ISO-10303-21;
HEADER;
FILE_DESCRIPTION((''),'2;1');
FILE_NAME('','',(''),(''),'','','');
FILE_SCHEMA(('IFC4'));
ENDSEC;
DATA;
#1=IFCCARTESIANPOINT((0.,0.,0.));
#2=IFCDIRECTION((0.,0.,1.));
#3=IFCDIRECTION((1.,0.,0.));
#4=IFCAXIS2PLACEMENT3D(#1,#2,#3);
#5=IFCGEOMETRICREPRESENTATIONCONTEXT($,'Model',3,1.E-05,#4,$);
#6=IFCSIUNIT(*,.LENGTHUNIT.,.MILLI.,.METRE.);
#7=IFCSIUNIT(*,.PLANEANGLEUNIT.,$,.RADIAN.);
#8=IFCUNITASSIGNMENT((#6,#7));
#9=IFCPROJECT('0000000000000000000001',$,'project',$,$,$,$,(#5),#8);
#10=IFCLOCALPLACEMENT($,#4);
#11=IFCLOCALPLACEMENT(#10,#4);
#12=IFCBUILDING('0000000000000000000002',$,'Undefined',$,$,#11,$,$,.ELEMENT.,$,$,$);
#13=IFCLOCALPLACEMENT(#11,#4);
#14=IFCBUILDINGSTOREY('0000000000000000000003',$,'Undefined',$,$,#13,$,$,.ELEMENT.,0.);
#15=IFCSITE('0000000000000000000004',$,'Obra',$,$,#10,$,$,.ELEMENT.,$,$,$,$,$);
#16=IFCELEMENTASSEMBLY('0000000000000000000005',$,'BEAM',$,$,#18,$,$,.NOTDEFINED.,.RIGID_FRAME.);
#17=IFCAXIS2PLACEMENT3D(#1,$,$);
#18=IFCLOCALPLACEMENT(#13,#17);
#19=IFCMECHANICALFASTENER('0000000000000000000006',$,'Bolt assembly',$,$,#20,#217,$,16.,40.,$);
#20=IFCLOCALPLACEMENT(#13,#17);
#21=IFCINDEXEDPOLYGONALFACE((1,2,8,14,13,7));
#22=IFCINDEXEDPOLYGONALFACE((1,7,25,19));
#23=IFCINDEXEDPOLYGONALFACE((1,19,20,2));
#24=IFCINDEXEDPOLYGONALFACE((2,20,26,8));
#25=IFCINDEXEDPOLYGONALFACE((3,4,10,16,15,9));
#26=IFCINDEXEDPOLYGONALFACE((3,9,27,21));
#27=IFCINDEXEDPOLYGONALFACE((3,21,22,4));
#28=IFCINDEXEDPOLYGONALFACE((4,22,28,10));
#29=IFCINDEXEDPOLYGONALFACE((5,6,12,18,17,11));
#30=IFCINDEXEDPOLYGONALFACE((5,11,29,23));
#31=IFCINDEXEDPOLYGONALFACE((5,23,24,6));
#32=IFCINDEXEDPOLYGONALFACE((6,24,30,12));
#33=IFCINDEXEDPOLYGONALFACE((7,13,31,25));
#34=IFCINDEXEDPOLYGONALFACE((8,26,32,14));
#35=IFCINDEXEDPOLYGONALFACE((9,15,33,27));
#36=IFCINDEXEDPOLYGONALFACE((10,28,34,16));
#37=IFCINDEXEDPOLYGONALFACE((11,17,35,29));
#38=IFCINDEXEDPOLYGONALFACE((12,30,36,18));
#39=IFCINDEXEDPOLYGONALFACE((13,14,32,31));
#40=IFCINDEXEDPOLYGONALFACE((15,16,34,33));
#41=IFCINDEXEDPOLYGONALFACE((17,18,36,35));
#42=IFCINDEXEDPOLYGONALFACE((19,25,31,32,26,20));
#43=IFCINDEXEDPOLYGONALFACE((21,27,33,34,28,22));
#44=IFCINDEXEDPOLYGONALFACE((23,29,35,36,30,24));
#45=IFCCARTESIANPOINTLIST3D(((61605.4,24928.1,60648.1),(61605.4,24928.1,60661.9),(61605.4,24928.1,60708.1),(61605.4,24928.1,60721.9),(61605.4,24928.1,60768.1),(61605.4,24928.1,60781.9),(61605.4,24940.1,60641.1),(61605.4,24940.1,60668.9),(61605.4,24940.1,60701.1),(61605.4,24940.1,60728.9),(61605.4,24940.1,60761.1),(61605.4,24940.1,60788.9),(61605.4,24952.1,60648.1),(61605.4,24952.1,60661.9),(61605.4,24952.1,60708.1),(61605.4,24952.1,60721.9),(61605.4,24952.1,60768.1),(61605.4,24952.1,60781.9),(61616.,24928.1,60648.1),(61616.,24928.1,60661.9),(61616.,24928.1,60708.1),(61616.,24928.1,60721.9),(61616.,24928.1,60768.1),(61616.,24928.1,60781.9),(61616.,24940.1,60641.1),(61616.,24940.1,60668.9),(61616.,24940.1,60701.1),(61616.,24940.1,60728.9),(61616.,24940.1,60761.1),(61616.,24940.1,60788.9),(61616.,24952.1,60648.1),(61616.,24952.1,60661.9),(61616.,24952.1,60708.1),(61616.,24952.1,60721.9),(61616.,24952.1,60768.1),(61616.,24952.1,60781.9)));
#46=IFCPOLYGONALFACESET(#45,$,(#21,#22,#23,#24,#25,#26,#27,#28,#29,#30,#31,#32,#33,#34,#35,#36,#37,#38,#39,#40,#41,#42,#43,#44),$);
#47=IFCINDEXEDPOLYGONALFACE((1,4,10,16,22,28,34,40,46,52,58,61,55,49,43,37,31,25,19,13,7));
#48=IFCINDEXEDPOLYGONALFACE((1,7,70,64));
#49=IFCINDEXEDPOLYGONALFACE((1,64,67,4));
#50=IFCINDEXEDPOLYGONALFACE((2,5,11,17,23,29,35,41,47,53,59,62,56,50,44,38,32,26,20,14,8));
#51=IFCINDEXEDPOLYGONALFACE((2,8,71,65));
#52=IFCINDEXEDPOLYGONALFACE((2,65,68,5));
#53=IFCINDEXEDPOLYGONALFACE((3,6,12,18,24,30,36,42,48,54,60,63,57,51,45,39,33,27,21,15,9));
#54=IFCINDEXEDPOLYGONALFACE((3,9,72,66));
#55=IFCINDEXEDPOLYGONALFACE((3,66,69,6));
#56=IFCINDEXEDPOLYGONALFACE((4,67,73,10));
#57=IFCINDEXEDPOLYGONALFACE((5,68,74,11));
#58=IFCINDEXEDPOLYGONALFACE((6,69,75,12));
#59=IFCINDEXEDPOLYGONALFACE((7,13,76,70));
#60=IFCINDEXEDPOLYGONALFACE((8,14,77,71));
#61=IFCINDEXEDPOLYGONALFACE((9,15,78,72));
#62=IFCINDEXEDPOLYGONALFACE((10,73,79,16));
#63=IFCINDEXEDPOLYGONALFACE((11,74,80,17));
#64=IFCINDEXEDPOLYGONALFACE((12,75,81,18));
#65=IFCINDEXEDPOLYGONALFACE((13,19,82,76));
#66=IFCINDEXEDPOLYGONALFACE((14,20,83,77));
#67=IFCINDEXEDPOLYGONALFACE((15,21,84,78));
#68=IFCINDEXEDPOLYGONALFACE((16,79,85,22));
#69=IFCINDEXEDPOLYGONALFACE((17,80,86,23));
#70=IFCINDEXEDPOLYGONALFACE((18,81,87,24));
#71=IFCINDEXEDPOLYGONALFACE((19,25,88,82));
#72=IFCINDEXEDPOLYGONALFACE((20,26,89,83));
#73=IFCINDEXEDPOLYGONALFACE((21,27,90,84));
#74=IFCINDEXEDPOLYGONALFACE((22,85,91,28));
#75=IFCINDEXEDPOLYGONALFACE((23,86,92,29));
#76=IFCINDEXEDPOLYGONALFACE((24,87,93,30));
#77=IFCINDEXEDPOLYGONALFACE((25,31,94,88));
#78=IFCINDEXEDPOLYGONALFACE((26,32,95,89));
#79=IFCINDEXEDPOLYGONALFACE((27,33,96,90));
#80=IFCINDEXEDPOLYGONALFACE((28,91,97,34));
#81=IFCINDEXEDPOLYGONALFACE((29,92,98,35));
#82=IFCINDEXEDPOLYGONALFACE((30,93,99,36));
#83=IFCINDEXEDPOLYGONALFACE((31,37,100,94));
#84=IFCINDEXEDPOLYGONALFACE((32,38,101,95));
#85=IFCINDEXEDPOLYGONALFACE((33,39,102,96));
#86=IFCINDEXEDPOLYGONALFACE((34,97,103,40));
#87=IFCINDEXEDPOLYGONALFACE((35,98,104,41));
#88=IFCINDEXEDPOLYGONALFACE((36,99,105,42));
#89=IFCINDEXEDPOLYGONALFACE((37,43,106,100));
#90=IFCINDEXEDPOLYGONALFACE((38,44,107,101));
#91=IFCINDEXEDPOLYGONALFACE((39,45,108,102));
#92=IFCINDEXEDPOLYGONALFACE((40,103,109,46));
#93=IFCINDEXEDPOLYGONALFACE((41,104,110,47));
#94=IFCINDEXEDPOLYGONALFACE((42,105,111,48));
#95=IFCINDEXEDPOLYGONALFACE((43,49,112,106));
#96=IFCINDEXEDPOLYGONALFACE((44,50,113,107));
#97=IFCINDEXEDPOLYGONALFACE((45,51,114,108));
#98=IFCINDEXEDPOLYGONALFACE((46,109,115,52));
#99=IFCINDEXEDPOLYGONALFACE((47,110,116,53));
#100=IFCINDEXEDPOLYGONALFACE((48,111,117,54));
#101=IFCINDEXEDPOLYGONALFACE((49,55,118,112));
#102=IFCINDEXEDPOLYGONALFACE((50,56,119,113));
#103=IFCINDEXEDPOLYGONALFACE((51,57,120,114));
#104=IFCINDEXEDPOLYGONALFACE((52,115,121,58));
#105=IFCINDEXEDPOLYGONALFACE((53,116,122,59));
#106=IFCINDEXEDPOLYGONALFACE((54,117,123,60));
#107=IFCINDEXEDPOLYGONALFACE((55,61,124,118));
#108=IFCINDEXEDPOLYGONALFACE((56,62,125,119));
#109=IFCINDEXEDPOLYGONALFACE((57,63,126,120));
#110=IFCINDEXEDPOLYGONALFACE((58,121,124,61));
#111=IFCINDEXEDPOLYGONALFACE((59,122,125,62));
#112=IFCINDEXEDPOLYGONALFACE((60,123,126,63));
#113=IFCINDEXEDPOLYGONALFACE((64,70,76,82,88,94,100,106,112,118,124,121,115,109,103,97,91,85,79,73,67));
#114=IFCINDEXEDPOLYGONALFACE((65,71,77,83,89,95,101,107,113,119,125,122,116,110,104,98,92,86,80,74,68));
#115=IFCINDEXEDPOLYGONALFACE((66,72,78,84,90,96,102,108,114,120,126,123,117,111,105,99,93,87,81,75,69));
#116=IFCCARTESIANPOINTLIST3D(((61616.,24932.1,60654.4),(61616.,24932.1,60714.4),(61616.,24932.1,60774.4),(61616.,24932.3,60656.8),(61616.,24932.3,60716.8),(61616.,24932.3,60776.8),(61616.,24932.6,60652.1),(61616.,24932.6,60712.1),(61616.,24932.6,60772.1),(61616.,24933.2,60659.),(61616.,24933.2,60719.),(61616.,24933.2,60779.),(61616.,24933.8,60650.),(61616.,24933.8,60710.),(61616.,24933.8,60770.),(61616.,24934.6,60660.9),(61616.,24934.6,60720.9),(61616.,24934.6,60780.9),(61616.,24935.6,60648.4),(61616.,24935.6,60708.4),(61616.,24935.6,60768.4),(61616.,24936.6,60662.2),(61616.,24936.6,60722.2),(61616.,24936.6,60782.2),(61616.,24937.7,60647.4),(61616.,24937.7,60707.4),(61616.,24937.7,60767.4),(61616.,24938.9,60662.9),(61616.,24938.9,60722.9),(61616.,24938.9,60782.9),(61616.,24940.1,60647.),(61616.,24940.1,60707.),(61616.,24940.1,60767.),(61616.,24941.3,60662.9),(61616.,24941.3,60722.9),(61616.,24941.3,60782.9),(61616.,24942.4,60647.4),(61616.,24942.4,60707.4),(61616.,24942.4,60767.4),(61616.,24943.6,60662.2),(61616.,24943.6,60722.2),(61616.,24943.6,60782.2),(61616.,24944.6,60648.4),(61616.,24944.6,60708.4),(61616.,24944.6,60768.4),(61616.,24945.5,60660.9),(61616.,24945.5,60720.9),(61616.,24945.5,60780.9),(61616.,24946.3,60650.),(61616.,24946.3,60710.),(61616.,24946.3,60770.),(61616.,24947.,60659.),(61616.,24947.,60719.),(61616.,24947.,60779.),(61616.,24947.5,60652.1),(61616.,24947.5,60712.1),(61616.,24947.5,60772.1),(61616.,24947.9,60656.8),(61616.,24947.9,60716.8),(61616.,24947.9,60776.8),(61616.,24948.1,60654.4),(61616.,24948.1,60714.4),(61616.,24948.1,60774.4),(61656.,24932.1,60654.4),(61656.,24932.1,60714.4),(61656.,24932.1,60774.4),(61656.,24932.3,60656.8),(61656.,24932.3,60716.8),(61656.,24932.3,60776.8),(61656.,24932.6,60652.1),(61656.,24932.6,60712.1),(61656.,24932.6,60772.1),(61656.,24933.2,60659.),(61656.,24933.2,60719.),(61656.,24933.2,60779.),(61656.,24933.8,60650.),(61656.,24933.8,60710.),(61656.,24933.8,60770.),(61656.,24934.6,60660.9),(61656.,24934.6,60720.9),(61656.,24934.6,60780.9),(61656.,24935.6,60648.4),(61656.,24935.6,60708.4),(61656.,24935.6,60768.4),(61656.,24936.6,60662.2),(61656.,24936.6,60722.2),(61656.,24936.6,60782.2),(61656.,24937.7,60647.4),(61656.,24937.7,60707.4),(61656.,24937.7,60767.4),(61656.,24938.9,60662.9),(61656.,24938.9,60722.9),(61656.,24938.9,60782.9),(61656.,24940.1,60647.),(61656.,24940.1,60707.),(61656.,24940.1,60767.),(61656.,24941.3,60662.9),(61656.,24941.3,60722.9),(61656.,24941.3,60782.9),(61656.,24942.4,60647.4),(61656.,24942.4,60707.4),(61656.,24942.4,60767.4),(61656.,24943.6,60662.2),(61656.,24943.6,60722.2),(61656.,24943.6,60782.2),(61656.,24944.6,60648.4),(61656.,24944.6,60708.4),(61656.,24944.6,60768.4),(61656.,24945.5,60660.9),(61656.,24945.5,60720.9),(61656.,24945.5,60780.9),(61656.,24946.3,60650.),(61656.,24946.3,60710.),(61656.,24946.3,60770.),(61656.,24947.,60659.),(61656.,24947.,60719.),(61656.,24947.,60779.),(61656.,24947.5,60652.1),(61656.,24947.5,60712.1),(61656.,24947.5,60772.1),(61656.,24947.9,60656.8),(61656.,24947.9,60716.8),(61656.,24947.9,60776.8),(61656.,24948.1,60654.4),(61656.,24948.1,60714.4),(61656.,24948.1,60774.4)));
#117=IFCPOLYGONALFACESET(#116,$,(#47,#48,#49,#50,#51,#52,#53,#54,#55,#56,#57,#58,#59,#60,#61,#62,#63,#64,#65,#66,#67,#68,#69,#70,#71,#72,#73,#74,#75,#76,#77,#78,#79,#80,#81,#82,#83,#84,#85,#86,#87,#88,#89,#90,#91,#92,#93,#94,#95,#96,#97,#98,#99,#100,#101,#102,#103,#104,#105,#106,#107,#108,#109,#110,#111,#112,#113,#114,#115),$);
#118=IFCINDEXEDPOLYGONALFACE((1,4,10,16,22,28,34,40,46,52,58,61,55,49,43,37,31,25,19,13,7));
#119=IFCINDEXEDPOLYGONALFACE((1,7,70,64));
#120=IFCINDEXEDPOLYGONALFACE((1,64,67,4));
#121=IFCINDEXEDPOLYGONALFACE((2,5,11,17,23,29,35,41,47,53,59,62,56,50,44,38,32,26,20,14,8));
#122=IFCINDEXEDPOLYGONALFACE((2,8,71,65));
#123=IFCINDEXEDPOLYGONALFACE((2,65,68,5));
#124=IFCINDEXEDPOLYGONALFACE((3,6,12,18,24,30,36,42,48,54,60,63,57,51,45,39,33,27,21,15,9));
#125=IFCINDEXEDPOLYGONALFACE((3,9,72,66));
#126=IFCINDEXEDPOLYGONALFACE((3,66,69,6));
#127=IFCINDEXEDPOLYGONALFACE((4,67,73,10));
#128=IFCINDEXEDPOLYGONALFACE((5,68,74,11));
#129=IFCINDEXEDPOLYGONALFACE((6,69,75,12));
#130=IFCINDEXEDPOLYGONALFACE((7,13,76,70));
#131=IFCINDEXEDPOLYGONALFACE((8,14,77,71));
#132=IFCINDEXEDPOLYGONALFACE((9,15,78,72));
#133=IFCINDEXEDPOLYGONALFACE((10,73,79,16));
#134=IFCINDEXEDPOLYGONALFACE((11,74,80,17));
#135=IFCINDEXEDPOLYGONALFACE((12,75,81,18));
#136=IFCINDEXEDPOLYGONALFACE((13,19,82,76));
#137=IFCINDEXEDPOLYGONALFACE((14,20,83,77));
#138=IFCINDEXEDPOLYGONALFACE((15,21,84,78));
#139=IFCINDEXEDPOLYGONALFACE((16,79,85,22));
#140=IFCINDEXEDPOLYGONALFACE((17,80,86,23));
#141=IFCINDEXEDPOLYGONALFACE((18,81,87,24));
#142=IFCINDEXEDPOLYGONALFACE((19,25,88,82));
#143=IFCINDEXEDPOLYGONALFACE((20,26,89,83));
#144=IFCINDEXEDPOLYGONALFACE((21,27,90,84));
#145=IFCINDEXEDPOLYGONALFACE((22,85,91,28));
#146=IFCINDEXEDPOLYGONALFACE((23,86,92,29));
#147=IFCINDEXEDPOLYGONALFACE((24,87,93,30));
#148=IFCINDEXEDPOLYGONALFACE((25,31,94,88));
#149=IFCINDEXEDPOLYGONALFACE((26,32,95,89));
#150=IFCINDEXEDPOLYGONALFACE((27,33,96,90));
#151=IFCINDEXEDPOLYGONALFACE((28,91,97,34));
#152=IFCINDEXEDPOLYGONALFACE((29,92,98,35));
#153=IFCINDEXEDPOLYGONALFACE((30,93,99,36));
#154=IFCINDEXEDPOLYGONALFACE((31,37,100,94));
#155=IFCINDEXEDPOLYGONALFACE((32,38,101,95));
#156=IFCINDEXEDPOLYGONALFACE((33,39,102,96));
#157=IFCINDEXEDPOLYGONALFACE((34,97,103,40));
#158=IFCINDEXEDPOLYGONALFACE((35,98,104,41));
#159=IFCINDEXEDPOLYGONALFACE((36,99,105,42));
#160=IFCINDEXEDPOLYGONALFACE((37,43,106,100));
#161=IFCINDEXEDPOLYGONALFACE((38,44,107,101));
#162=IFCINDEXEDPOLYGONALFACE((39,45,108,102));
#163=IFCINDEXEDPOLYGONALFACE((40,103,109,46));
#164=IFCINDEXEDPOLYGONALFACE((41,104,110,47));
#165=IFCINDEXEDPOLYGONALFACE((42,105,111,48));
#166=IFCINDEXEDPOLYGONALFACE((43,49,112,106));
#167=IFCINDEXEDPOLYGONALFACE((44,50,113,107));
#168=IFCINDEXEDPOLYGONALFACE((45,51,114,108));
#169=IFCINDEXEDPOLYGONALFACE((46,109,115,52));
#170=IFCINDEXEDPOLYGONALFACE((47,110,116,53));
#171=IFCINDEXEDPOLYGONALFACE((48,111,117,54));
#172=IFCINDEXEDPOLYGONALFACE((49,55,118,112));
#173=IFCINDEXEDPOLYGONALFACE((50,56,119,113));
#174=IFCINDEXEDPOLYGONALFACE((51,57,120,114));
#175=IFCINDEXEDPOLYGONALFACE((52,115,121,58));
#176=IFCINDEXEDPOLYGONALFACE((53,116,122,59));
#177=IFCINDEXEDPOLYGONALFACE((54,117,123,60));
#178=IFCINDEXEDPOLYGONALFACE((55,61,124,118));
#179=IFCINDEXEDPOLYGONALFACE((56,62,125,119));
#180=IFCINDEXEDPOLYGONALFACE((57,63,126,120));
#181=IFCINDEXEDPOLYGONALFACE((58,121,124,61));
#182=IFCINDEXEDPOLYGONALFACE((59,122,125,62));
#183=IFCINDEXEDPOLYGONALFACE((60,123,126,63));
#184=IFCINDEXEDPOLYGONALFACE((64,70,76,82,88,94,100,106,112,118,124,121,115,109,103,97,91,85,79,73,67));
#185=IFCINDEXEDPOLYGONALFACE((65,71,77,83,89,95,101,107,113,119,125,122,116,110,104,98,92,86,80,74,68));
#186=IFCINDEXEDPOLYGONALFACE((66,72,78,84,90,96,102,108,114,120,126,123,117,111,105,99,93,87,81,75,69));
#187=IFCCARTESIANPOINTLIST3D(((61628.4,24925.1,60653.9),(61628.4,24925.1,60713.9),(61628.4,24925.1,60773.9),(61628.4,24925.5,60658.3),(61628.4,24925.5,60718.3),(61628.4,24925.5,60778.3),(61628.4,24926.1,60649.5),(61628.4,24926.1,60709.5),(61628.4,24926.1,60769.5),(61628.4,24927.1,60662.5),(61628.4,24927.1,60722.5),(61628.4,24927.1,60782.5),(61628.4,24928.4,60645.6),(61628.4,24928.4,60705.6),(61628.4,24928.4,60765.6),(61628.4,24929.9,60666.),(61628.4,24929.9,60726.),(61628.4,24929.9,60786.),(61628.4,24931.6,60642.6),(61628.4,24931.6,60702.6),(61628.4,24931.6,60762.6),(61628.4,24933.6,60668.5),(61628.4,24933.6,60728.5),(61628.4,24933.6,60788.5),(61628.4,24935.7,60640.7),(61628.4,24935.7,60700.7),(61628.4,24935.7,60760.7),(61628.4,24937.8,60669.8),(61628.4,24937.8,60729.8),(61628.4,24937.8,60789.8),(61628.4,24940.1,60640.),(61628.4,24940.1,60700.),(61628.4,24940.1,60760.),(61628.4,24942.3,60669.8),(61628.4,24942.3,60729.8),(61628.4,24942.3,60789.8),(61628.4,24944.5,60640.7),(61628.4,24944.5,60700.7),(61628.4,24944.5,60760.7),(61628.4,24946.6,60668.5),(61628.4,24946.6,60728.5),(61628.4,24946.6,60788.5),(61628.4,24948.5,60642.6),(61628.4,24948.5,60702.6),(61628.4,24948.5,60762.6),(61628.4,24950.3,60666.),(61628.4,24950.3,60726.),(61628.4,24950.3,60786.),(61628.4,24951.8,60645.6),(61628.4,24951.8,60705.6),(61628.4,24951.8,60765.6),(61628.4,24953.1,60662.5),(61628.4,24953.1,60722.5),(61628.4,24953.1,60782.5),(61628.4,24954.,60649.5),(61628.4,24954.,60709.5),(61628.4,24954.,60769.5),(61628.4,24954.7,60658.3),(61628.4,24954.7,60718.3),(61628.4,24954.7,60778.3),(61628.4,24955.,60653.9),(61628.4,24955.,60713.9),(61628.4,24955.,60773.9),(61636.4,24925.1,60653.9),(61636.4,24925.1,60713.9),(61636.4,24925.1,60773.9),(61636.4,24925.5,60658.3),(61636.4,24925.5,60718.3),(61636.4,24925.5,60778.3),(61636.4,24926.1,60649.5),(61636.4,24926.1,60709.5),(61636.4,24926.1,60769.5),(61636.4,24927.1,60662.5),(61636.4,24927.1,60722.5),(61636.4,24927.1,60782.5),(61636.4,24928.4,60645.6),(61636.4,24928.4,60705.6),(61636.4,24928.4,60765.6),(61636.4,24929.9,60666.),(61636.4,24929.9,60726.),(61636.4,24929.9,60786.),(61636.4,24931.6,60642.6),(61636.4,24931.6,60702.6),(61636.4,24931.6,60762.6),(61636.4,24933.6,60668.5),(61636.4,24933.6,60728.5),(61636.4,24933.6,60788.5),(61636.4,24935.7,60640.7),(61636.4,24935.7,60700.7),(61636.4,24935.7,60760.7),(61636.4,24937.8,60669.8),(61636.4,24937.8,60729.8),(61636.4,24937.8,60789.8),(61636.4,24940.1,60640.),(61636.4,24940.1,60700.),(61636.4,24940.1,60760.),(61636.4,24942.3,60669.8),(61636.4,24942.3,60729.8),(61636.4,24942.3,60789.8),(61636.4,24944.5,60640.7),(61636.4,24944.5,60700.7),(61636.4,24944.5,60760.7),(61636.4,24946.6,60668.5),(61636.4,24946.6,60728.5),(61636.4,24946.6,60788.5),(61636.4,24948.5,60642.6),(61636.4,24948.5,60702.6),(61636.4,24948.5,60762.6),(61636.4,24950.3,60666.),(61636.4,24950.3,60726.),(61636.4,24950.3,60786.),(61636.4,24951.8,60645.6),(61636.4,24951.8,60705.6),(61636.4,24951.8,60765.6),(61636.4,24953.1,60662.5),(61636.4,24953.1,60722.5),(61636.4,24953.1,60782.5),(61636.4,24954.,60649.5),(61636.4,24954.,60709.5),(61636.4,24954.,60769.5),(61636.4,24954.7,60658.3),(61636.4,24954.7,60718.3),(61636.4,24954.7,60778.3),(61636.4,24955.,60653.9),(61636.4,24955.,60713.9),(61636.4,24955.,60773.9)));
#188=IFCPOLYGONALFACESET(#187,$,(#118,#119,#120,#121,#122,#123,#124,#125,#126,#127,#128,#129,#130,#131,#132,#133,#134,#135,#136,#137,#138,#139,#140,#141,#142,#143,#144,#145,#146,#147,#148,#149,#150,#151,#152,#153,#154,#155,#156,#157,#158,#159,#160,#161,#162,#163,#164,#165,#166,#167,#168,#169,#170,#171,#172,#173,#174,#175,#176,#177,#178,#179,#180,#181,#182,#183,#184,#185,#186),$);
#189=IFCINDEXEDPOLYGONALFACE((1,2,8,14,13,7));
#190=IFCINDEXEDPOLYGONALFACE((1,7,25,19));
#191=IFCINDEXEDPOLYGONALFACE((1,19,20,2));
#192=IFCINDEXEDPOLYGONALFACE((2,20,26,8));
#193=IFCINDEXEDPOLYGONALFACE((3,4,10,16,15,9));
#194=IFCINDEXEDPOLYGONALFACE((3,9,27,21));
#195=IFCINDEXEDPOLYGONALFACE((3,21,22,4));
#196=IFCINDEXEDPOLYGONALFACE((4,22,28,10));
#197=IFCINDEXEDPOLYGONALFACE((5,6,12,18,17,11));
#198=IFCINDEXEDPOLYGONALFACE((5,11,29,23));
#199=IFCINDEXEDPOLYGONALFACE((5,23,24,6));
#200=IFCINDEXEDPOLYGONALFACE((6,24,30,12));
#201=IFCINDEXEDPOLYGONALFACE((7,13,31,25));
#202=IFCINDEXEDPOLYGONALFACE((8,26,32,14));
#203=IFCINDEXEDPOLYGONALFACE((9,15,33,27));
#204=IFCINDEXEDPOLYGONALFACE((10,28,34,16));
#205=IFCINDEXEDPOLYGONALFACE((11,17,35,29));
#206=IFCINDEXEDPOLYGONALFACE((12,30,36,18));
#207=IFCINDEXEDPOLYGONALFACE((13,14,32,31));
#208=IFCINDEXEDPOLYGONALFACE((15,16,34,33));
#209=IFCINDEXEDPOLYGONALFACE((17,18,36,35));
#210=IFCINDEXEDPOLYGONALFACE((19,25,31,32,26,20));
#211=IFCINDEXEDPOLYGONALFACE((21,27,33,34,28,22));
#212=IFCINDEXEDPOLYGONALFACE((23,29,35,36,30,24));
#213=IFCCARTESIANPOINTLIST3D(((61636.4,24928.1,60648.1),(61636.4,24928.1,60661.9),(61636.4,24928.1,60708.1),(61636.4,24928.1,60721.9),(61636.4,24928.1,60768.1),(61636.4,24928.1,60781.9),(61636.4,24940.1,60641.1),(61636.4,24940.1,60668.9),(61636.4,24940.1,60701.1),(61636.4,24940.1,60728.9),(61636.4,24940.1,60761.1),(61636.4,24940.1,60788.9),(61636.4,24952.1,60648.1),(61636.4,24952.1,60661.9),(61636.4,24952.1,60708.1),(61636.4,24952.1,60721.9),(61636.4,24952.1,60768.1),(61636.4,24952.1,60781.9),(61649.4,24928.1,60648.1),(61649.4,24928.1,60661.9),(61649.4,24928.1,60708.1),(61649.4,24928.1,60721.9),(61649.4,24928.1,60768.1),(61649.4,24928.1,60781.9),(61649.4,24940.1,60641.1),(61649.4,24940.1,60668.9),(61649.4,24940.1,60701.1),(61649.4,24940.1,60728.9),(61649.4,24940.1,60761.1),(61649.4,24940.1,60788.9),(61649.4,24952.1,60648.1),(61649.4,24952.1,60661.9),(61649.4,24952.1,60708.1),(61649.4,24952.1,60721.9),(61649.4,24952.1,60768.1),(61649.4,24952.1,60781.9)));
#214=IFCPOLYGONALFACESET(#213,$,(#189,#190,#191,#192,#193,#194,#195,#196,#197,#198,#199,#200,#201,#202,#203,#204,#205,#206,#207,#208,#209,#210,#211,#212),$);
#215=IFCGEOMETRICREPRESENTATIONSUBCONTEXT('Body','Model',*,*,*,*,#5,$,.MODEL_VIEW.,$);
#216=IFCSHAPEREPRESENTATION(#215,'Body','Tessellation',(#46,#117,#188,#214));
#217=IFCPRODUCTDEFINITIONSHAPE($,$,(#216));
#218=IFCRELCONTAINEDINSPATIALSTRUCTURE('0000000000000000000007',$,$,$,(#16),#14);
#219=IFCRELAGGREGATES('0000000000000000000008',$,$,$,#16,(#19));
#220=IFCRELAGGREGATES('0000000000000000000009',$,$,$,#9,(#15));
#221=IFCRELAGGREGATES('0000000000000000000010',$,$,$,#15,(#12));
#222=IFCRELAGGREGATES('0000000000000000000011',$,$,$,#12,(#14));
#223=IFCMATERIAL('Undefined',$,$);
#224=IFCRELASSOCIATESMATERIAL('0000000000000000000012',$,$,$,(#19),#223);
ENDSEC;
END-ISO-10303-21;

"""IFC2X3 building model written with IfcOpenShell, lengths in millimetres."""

from ifc_helpers import new_model, si_unit, frame, origin_with_axes, origin_2d_with_axis, place, context, subcontext, project, spatial, polyline, circle, outline, extrude, source, transform, mapped, material, element, aggregate, save


model = new_model("IFC2X3")

# Units and contexts
model_context = context("Model", 3, precision=1e-05, world=origin_with_axes())
body_context = subcontext(model_context, "Body", "Model", "MODEL_VIEW")
ifc_project = project(units=[si_unit("LENGTHUNIT", "METRE", prefix="MILLI"), si_unit("PLANEANGLEUNIT", "RADIAN")], contexts=[model_context])

# Site, building, storey
site_placement = place(None, origin_with_axes())
site = spatial("IfcSite", under=ifc_project, at=site_placement, Name="Obra", CompositionType="ELEMENT")
building_placement = place(site_placement, origin_with_axes())
building = spatial("IfcBuilding", under=site, at=building_placement, Name="Undefined", CompositionType="ELEMENT")
storey_placement = place(building_placement, origin_with_axes())
storey = spatial("IfcBuildingStorey", under=building, at=storey_placement, Name="Undefined", CompositionType="ELEMENT", Elevation=0.0)

# Element assembly
ifc_material_1 = material(Name="Undefined")
assembly_1_placement = place(storey_placement, origin_with_axes())
assembly_1 = element("IfcElementAssembly", 1, at=assembly_1_placement, inside=storey, Name="BEAM", AssemblyPlace="NOTDEFINED", PredefinedType="RIGID_FRAME")

# Mechanical fastener
shared_shape_1 = source(origin_with_axes(), body_context, "Body", "SweptSolid", [
    extrude(outline(polyline([(13.9, 0.0), (6.9, 12.0), (-6.9, 12.0), (-13.9, 0.0), (-6.9, -12.0), (6.9, -12.0), (13.9, 0.0)])), frame((0.0, -19.7, 0.0), z_axis=(0.0, 1.0, 0.0), x_axis=(1.0, 0.0, 0.0)), (0.0, 0.0, 1.0), 10.6),
    extrude(circle(Radius=8.0, at=origin_2d_with_axis()), frame((0.0, -9.1, 0.0), z_axis=(0.0, 1.0, 0.0), x_axis=(1.0, 0.0, 0.0)), (0.0, 0.0, 1.0), 40.0),
    extrude(circle(Radius=15.0, at=origin_2d_with_axis()), frame((0.0, 3.3, 0.0), z_axis=(0.0, 1.0, 0.0), x_axis=(1.0, 0.0, 0.0)), (0.0, 0.0, 1.0), 8.0),
    extrude(outline(polyline([(13.9, 0.0), (6.9, 12.0), (-6.9, 12.0), (-13.9, 0.0), (-6.9, -12.0), (6.9, -12.0), (13.9, 0.0)])), frame((0.0, 11.3, 0.0), z_axis=(0.0, 1.0, 0.0), x_axis=(1.0, 0.0, 0.0)), (0.0, 0.0, 1.0), 13.0),
])
mechanical_fastener_1_placement = place(assembly_1_placement, frame((61625.1, 24990.1, 60835.0), z_axis=(0.000002, -1.0, 0.0), x_axis=(0.0, 0.0, -1.0)))
mechanical_fastener_1 = element("IfcMechanicalFastener", 2, at=mechanical_fastener_1_placement, material=ifc_material_1, Name="Bolt assembly", NominalDiameter=16.0, NominalLength=40.0, context=body_context, shape_type="MappedRepresentation", body=[
    mapped(shared_shape_1, transform((60.0, 0.0, 50.0))),
    mapped(shared_shape_1, transform((120.0, 0.0, 50.0))),
    mapped(shared_shape_1, transform((180.0, 0.0, 50.0))),
])
aggregate(assembly_1, [mechanical_fastener_1])

save(model, "model.ifc")
